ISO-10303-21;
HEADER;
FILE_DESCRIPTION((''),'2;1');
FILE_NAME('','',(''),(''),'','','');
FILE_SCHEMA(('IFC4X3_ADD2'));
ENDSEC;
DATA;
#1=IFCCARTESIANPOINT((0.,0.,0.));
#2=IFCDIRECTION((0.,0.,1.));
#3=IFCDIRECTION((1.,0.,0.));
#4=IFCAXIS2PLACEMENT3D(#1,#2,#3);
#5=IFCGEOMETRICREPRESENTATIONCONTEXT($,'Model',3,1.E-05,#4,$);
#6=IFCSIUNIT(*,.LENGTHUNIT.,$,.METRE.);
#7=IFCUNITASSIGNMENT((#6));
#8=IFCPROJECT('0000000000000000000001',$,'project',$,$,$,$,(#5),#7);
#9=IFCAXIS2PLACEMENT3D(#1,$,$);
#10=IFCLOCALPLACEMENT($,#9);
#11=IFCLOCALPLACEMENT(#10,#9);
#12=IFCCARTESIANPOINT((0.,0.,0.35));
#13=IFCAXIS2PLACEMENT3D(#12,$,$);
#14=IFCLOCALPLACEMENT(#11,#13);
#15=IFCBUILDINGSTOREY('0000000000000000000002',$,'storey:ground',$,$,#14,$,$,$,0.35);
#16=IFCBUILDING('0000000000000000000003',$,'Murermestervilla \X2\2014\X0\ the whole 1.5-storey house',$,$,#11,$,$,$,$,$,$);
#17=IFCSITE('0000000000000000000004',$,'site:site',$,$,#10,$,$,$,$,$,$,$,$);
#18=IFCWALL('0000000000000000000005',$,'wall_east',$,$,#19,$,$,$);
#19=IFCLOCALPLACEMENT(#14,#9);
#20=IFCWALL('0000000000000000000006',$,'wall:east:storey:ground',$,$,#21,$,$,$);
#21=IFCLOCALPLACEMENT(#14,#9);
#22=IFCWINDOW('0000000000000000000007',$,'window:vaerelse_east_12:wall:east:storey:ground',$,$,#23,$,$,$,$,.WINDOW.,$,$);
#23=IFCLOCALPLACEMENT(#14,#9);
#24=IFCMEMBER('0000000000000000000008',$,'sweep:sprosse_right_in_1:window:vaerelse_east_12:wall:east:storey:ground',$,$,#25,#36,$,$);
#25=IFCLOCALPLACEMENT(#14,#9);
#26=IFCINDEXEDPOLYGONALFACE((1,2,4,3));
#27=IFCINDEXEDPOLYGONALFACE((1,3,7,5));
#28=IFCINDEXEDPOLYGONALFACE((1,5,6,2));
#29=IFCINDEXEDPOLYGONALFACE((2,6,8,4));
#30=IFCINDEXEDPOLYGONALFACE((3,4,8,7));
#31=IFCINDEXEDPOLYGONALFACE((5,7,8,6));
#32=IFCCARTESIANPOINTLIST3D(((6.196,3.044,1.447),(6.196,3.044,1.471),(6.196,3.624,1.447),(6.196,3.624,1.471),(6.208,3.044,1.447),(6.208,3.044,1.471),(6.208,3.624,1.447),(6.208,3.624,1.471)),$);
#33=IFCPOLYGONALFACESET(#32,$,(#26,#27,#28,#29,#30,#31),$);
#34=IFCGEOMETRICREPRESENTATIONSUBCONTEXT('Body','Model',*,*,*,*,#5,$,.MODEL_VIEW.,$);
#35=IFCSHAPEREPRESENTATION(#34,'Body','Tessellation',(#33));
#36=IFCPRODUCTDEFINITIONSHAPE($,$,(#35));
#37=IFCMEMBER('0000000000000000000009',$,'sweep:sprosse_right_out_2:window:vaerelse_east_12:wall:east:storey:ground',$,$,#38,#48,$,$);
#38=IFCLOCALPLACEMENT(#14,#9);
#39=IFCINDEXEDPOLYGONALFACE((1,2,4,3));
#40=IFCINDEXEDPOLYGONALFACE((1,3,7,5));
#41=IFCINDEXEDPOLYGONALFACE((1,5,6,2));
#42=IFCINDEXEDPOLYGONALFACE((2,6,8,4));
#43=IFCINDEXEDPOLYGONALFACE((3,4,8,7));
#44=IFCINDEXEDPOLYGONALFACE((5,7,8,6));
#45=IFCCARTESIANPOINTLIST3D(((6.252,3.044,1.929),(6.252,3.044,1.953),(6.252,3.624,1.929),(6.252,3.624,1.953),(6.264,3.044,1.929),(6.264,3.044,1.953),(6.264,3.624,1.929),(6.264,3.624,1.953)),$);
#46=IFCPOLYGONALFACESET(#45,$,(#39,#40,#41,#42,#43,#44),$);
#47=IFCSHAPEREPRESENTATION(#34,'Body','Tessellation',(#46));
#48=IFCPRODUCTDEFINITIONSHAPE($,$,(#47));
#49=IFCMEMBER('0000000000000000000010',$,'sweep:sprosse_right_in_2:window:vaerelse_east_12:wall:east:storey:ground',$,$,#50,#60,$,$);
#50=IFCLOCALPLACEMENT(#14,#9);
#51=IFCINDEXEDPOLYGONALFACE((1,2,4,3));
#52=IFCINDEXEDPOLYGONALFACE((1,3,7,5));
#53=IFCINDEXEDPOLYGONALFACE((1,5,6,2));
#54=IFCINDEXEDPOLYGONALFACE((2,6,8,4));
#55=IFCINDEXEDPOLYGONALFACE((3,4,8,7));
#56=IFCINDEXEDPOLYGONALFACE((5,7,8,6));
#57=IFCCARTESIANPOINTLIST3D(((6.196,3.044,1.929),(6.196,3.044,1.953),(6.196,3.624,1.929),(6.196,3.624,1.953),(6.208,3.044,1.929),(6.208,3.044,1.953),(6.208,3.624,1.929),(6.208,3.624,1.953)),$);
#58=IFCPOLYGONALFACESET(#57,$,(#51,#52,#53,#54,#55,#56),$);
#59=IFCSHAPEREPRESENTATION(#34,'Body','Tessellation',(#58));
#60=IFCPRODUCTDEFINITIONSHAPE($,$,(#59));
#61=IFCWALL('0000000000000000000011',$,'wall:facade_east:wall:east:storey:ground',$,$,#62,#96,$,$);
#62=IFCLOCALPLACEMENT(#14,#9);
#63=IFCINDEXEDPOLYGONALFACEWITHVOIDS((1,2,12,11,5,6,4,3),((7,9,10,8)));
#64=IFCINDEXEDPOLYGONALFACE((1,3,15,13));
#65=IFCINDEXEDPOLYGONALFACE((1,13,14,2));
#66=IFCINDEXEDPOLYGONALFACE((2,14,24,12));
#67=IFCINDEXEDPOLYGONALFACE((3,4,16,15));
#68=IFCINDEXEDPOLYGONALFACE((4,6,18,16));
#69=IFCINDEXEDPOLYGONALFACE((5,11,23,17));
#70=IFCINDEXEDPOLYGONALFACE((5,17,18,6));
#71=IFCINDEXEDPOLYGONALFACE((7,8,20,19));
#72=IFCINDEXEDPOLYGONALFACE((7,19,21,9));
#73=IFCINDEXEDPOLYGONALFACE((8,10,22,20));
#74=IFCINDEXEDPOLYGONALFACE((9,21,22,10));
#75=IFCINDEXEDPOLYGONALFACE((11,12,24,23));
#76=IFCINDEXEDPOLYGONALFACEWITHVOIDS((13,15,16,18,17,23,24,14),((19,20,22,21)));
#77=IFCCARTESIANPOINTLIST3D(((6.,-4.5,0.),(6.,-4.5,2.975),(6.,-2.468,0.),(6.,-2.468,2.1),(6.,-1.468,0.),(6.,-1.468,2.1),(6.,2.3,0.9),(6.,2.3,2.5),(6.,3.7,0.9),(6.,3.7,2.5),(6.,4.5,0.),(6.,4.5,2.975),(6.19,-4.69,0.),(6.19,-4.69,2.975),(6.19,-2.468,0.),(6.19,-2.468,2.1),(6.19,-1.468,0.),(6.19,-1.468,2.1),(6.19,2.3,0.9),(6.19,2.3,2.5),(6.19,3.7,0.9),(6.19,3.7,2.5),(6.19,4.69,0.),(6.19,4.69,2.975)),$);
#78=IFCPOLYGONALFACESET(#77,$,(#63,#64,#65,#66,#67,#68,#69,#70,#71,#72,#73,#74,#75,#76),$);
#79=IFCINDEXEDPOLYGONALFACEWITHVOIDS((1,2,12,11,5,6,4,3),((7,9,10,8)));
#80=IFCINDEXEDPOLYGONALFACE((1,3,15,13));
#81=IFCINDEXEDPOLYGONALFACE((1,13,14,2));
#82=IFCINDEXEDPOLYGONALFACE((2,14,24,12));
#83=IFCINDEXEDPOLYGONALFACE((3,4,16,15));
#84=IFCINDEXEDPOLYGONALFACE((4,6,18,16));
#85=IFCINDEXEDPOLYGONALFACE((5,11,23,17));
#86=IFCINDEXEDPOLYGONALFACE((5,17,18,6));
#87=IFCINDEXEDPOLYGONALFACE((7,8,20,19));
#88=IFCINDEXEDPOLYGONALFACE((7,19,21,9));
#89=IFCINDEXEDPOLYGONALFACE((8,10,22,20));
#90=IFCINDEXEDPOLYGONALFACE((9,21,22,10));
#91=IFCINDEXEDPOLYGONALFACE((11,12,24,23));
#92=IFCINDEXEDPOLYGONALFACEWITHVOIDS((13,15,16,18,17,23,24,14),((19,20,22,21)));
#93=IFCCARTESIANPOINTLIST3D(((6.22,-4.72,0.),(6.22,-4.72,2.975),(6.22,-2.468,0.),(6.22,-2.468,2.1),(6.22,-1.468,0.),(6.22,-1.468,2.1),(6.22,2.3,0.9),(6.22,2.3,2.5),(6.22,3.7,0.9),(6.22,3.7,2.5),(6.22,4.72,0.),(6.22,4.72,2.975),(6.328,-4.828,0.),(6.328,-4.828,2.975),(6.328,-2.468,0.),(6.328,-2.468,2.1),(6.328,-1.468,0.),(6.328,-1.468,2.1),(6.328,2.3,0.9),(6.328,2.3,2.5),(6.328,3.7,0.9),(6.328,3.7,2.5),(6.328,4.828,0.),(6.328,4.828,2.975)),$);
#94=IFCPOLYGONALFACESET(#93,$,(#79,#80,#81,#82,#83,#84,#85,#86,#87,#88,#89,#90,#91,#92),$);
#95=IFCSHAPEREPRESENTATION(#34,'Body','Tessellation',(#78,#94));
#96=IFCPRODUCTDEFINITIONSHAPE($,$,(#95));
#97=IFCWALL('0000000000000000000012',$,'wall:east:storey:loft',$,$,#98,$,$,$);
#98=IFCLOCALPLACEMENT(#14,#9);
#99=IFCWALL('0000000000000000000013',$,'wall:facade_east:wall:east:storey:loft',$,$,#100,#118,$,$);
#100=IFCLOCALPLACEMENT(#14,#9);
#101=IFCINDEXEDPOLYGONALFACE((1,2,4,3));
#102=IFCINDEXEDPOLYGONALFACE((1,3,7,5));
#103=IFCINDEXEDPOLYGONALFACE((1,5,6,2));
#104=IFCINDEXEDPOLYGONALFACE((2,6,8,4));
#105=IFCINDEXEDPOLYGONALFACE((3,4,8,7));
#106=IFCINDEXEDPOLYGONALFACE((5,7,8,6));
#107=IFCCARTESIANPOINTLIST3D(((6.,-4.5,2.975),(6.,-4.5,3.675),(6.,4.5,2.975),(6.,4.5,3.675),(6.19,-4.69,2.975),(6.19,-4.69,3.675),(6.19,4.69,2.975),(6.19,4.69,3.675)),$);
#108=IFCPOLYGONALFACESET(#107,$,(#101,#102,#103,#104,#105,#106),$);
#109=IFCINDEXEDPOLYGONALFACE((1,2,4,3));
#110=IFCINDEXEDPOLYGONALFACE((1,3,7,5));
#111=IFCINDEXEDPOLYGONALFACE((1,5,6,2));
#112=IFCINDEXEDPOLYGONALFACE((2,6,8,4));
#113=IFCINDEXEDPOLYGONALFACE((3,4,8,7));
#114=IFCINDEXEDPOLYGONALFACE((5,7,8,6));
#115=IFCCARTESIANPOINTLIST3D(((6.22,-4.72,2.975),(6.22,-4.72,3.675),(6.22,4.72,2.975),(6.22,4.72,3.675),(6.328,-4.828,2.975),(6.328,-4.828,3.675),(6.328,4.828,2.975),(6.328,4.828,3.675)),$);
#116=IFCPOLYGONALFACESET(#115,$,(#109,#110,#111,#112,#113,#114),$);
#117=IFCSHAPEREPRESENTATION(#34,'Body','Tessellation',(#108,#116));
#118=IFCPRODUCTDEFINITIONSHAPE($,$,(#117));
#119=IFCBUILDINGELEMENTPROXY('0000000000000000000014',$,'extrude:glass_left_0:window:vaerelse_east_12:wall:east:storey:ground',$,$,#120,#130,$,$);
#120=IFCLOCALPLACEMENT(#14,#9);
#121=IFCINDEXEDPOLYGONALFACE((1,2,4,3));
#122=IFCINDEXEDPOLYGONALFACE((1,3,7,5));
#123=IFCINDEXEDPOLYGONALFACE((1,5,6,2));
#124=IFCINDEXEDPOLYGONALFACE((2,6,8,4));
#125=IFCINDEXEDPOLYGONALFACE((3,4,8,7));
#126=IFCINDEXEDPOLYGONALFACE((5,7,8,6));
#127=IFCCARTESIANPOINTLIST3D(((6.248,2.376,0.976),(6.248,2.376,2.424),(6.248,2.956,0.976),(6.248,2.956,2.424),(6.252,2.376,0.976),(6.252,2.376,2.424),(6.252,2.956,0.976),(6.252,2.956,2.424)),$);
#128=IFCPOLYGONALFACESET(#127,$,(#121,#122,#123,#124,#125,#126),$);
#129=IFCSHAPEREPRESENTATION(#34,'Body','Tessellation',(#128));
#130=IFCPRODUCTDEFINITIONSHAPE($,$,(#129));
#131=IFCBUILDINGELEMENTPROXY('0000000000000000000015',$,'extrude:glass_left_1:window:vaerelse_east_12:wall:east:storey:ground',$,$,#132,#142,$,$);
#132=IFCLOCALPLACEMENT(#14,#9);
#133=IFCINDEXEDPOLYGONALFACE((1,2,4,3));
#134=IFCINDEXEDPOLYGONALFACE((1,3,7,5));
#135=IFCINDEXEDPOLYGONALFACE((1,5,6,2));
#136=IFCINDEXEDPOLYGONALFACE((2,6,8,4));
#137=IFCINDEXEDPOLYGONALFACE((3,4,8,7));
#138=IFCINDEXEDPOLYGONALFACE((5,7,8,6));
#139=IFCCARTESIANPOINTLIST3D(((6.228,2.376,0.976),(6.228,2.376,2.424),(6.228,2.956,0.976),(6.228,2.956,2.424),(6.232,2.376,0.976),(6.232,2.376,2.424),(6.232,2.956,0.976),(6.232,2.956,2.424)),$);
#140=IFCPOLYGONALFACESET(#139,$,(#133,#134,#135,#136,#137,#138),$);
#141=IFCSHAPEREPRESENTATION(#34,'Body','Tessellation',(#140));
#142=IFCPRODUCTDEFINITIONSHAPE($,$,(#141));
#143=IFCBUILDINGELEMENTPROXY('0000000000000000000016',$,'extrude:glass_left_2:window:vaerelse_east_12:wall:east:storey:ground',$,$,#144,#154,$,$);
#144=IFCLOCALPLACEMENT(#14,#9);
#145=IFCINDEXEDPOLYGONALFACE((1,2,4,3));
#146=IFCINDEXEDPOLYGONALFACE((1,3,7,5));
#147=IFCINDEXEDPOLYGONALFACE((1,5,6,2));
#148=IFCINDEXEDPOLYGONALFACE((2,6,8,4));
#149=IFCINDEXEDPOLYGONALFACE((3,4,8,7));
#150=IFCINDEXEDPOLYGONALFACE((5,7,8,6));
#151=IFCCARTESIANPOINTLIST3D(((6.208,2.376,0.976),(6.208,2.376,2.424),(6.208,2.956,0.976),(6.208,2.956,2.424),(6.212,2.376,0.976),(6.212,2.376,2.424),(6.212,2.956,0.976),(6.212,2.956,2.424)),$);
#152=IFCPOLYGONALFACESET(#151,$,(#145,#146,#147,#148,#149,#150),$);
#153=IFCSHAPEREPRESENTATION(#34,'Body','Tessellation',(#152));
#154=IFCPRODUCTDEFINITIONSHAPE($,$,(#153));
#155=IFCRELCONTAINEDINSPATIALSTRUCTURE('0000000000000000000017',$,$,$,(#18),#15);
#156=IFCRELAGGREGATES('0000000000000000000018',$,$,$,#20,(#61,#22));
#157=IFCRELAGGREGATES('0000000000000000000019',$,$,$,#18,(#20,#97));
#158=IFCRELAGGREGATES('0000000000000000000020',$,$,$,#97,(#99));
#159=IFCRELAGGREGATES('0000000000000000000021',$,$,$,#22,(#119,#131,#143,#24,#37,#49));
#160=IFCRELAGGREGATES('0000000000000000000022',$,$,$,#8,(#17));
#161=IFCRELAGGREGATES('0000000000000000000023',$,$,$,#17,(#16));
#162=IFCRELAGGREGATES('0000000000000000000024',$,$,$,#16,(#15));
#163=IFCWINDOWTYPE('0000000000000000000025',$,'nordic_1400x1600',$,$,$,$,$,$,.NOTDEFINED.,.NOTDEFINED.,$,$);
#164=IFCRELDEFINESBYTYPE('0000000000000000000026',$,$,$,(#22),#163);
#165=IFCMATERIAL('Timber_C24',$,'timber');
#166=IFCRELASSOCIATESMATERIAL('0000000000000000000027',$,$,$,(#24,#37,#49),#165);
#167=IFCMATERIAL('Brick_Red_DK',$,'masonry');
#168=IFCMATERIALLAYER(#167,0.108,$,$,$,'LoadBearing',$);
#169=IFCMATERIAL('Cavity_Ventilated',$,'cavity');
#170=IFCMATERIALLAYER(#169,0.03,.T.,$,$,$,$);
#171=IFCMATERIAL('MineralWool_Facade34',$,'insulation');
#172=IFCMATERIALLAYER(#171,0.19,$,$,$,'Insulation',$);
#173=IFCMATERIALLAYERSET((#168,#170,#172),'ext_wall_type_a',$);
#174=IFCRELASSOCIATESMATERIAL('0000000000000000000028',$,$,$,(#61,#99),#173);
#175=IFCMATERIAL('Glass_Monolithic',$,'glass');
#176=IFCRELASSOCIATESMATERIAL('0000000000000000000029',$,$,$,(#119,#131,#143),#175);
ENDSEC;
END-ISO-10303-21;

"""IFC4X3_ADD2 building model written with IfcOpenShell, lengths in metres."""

from ifc_helpers import new_model, si_unit, frame, origin, origin_with_axes, place, context, subcontext, project, spatial, polyline, rectangle, outline, extrude, clip, halfspace, source, transform, mapped, material, layer, layer_set, layer_usage, type_object, type_shapes, element, fill, aggregate, save


model = new_model("IFC4X3_ADD2")

# Units and contexts
model_context = context("Model", 3, precision=1e-05, world=origin_with_axes())
body_context = subcontext(model_context, "Body", "Model", "MODEL_VIEW")
ifc_project = project(units=[si_unit("LENGTHUNIT", "METRE")], contexts=[model_context])

# Site, building, storey
placement_1 = place(None, origin())
site = spatial("IfcSite", under=ifc_project, at=placement_1, Name="site:site")
building_placement = place(placement_1, origin())
building = spatial("IfcBuilding", under=site, at=building_placement, Name="Murermestervilla — the whole 1.5-storey house")
storey_placement = place(building_placement, frame((0.0, 0.0, 0.35)))
storey = spatial("IfcBuildingStorey", under=building, at=storey_placement, Name="storey:ground", Elevation=0.35)

# Walls, window, members, openings
wall_1_placement = place(storey_placement, origin())
wall_1 = element("IfcWall", 1, at=wall_1_placement, inside=storey, Name="wall_east")
placement_2 = place(wall_1_placement, frame((0.0, 0.0, -0.35)))
wall_2 = element("IfcWall", 2, at=placement_2, Name="wall:east:storey:ground")
window_type = type_object("IfcWindowType", Name="nordic_1400x1600", PartitioningType="NOTDEFINED", PredefinedType="NOTDEFINED")
window_placement = place(None, frame((6.328, 3.0, 1.25), z_axis=(0.0, 0.0, 1.0), x_axis=(0.0, 1.0, 0.0)))
window = element("IfcWindow", 3, at=window_placement, type_object=window_type, Name="window:vaerelse_east_12:wall:east:storey:ground", PredefinedType="WINDOW")
ifc_material_1 = material(Name="Timber_C24", Category="timber")
shared_shape_1 = source(origin(), body_context, "Body", "SweptSolid", [
    extrude(outline(polyline([(-0.006, -0.012), (0.006, -0.012), (0.006, 0.012), (-0.006, 0.012), (-0.006, -0.012)])), frame((0.044, 0.126, 0.559), z_axis=(1.0, 0.0, 0.0), x_axis=(0.0, 1.0, 0.0)), (0.0, 0.0, 1.0), 0.58),
])
placement_3 = place(window_placement, origin())
member_1 = element("IfcMember", 4, at=placement_3, material=ifc_material_1, Name="sweep:sprosse_right_in_1:window:vaerelse_east_12:wall:east:storey:ground", context=body_context, shape_type="MappedRepresentation", body=[
    mapped(shared_shape_1, transform((0.0, 0.0, 0.0))),
])
shared_shape_2 = source(origin(), body_context, "Body", "SweptSolid", [
    extrude(outline(polyline([(-0.006, -0.012), (0.006, -0.012), (0.006, 0.012), (-0.006, 0.012), (-0.006, -0.012)])), frame((0.044, 0.07, 1.041), z_axis=(1.0, 0.0, 0.0), x_axis=(0.0, 1.0, 0.0)), (0.0, 0.0, 1.0), 0.58),
])
member_2 = element("IfcMember", 5, at=placement_3, material=ifc_material_1, Name="sweep:sprosse_right_out_2:window:vaerelse_east_12:wall:east:storey:ground", context=body_context, shape_type="MappedRepresentation", body=[
    mapped(shared_shape_2, transform((0.0, 0.0, 0.0))),
])
shared_shape_3 = source(origin(), body_context, "Body", "SweptSolid", [
    extrude(outline(polyline([(-0.006, -0.012), (0.006, -0.012), (0.006, 0.012), (-0.006, 0.012), (-0.006, -0.012)])), frame((0.044, 0.126, 1.041), z_axis=(1.0, 0.0, 0.0), x_axis=(0.0, 1.0, 0.0)), (0.0, 0.0, 1.0), 0.58),
])
member_3 = element("IfcMember", 6, at=placement_3, material=ifc_material_1, Name="sweep:sprosse_right_in_2:window:vaerelse_east_12:wall:east:storey:ground", context=body_context, shape_type="MappedRepresentation", body=[
    mapped(shared_shape_3, transform((0.0, 0.0, 0.0))),
])
ifc_material_2 = material(Name="Brick_Red_DK", Category="masonry")
ifc_layer_1 = layer(ifc_material_2, 0.108, Category="LoadBearing")
ifc_material_3 = material(Name="Cavity_Ventilated", Category="cavity")
ifc_layer_2 = layer(ifc_material_3, 0.03, ventilated=True)
ifc_material_4 = material(Name="MineralWool_Facade34", Category="insulation")
ifc_layer_3 = layer(ifc_material_4, 0.19, Category="Insulation")
ifc_layer_set_1 = layer_set([ifc_layer_1, ifc_layer_2, ifc_layer_3], Name="ext_wall_type_a")
ifc_layer_usage_1 = layer_usage(ifc_layer_set_1, "AXIS1", "NEGATIVE", 0.164)
wall_3_placement = place(None, frame((6.164, 0.0, 1.8375)))
wall_3 = element("IfcWall", 7, at=wall_3_placement, material=ifc_layer_usage_1, Name="wall:facade_east:wall:east:storey:ground", context=body_context, shape_type="CSG", body=[
    clip(clip(extrude(rectangle(XDim=0.19, YDim=9.656), frame((-0.069, 0.0, -1.4875)), (0.0, 0.0, 1.0), 2.975), halfspace(frame((0.164, -4.828, -1.4875), z_axis=(0.707107, 0.707107, 0.0), x_axis=(0.707107, -0.707107, 0.0)), True)), halfspace(frame((0.164, 4.828, -1.4875), z_axis=(0.707107, -0.707107, 0.0), x_axis=(-0.707107, -0.707107, 0.0)), True)),
    clip(clip(extrude(rectangle(XDim=0.108, YDim=9.656), frame((0.11, 0.0, -1.4875)), (0.0, 0.0, 1.0), 2.975), halfspace(frame((0.164, -4.828, -1.4875), z_axis=(0.707107, 0.707107, 0.0), x_axis=(0.707107, -0.707107, 0.0)), True)), halfspace(frame((0.164, 4.828, -1.4875), z_axis=(0.707107, -0.707107, 0.0), x_axis=(-0.707107, -0.707107, 0.0)), True)),
])
opening_1_placement = place(wall_3_placement, frame((-0.09, 3.0, -0.5875), z_axis=(0.0, 0.0, 1.0), x_axis=(0.0, 1.0, 0.0)))
opening_1 = element("IfcOpeningElement", 8, at=opening_1_placement, cuts=wall_3, context=body_context, shape_type="SweptSolid", body=[
    extrude(rectangle(XDim=1.4, YDim=0.508), origin(), (0.0, 0.0, 1.0), 1.6),
])
fill(opening_1, window)
opening_2_placement = place(wall_3_placement, frame((-0.09, -1.968, -1.4875), z_axis=(0.0, 0.0, 1.0), x_axis=(0.0, 1.0, 0.0)))
element("IfcOpeningElement", 9, at=opening_2_placement, cuts=wall_3, context=body_context, shape_type="SweptSolid", body=[
    extrude(rectangle(XDim=1.0, YDim=0.508), origin(), (0.0, 0.0, 1.0), 2.1),
])
aggregate(wall_2, [wall_3, window])

# Walls
wall_4 = element("IfcWall", 10, at=placement_2, Name="wall:east:storey:loft")
aggregate(wall_1, [wall_2, wall_4])
wall_5_placement = place(None, frame((6.164, 0.0, 3.675)))
wall_5 = element("IfcWall", 11, at=wall_5_placement, material=ifc_layer_usage_1, Name="wall:facade_east:wall:east:storey:loft", context=body_context, shape_type="CSG", body=[
    clip(clip(extrude(rectangle(XDim=0.19, YDim=9.6561), frame((-0.069, 0.0, -0.35)), (0.0, 0.0, 1.0), 0.7), halfspace(frame((0.164, -4.828, -0.35), z_axis=(0.707107, 0.707107, 0.0), x_axis=(0.707107, -0.707107, 0.0)), True)), halfspace(frame((0.164, 4.828, -0.35), z_axis=(0.707107, -0.707107, 0.0), x_axis=(-0.707107, -0.707107, 0.0)), True)),
    clip(clip(extrude(rectangle(XDim=0.108, YDim=9.6561), frame((0.11, 0.0, -0.35)), (0.0, 0.0, 1.0), 0.7), halfspace(frame((0.164, -4.828, -0.35), z_axis=(0.707107, 0.707107, 0.0), x_axis=(0.707107, -0.707107, 0.0)), True)), halfspace(frame((0.164, 4.828, -0.35), z_axis=(0.707107, -0.707107, 0.0), x_axis=(-0.707107, -0.707107, 0.0)), True)),
])
aggregate(wall_4, [wall_5])

# Building element proxies
ifc_material_5 = material(Name="Glass_Monolithic", Category="glass")
shared_shape_4 = source(origin(), body_context, "Body", "SweptSolid", [
    extrude(outline(polyline([(-0.29, -0.724), (0.29, -0.724), (0.29, 0.724), (-0.29, 0.724), (-0.29, -0.724)])), frame((0.0, 0.0, -0.002)), (0.0, 0.0, 1.0), 0.004),
])
proxy_1_placement = place(None, frame((6.25, 2.666, 2.05), z_axis=(1.0, 0.0, 0.0), x_axis=(0.0, 1.0, 0.0)))
proxy_1 = element("IfcBuildingElementProxy", 12, at=proxy_1_placement, material=ifc_material_5, Name="extrude:glass_left_0:window:vaerelse_east_12:wall:east:storey:ground", context=body_context, shape_type="MappedRepresentation", body=[
    mapped(shared_shape_4, transform((0.0, 0.0, 0.0))),
])
shared_shape_5 = source(origin(), body_context, "Body", "SweptSolid", [
    extrude(outline(polyline([(-0.29, -0.724), (0.29, -0.724), (0.29, 0.724), (-0.29, 0.724), (-0.29, -0.724)])), frame((0.0, 0.0, -0.002)), (0.0, 0.0, 1.0), 0.004),
])
proxy_2_placement = place(None, frame((6.23, 2.666, 2.05), z_axis=(1.0, 0.0, 0.0), x_axis=(0.0, 1.0, 0.0)))
proxy_2 = element("IfcBuildingElementProxy", 13, at=proxy_2_placement, material=ifc_material_5, Name="extrude:glass_left_1:window:vaerelse_east_12:wall:east:storey:ground", context=body_context, shape_type="MappedRepresentation", body=[
    mapped(shared_shape_5, transform((0.0, 0.0, 0.0))),
])
shared_shape_6 = source(origin(), body_context, "Body", "SweptSolid", [
    extrude(outline(polyline([(-0.29, -0.724), (0.29, -0.724), (0.29, 0.724), (-0.29, 0.724), (-0.29, -0.724)])), frame((0.0, 0.0, -0.002)), (0.0, 0.0, 1.0), 0.004),
])
type_shapes(window_type, [shared_shape_4, shared_shape_5, shared_shape_6, shared_shape_1, shared_shape_2, shared_shape_3])
proxy_3_placement = place(None, frame((6.21, 2.666, 2.05), z_axis=(1.0, 0.0, 0.0), x_axis=(0.0, 1.0, 0.0)))
proxy_3 = element("IfcBuildingElementProxy", 14, at=proxy_3_placement, material=ifc_material_5, Name="extrude:glass_left_2:window:vaerelse_east_12:wall:east:storey:ground", context=body_context, shape_type="MappedRepresentation", body=[
    mapped(shared_shape_6, transform((0.0, 0.0, 0.0))),
])
aggregate(window, [proxy_1, proxy_2, proxy_3, member_1, member_2, member_3])

save(model, "model.ifc")
